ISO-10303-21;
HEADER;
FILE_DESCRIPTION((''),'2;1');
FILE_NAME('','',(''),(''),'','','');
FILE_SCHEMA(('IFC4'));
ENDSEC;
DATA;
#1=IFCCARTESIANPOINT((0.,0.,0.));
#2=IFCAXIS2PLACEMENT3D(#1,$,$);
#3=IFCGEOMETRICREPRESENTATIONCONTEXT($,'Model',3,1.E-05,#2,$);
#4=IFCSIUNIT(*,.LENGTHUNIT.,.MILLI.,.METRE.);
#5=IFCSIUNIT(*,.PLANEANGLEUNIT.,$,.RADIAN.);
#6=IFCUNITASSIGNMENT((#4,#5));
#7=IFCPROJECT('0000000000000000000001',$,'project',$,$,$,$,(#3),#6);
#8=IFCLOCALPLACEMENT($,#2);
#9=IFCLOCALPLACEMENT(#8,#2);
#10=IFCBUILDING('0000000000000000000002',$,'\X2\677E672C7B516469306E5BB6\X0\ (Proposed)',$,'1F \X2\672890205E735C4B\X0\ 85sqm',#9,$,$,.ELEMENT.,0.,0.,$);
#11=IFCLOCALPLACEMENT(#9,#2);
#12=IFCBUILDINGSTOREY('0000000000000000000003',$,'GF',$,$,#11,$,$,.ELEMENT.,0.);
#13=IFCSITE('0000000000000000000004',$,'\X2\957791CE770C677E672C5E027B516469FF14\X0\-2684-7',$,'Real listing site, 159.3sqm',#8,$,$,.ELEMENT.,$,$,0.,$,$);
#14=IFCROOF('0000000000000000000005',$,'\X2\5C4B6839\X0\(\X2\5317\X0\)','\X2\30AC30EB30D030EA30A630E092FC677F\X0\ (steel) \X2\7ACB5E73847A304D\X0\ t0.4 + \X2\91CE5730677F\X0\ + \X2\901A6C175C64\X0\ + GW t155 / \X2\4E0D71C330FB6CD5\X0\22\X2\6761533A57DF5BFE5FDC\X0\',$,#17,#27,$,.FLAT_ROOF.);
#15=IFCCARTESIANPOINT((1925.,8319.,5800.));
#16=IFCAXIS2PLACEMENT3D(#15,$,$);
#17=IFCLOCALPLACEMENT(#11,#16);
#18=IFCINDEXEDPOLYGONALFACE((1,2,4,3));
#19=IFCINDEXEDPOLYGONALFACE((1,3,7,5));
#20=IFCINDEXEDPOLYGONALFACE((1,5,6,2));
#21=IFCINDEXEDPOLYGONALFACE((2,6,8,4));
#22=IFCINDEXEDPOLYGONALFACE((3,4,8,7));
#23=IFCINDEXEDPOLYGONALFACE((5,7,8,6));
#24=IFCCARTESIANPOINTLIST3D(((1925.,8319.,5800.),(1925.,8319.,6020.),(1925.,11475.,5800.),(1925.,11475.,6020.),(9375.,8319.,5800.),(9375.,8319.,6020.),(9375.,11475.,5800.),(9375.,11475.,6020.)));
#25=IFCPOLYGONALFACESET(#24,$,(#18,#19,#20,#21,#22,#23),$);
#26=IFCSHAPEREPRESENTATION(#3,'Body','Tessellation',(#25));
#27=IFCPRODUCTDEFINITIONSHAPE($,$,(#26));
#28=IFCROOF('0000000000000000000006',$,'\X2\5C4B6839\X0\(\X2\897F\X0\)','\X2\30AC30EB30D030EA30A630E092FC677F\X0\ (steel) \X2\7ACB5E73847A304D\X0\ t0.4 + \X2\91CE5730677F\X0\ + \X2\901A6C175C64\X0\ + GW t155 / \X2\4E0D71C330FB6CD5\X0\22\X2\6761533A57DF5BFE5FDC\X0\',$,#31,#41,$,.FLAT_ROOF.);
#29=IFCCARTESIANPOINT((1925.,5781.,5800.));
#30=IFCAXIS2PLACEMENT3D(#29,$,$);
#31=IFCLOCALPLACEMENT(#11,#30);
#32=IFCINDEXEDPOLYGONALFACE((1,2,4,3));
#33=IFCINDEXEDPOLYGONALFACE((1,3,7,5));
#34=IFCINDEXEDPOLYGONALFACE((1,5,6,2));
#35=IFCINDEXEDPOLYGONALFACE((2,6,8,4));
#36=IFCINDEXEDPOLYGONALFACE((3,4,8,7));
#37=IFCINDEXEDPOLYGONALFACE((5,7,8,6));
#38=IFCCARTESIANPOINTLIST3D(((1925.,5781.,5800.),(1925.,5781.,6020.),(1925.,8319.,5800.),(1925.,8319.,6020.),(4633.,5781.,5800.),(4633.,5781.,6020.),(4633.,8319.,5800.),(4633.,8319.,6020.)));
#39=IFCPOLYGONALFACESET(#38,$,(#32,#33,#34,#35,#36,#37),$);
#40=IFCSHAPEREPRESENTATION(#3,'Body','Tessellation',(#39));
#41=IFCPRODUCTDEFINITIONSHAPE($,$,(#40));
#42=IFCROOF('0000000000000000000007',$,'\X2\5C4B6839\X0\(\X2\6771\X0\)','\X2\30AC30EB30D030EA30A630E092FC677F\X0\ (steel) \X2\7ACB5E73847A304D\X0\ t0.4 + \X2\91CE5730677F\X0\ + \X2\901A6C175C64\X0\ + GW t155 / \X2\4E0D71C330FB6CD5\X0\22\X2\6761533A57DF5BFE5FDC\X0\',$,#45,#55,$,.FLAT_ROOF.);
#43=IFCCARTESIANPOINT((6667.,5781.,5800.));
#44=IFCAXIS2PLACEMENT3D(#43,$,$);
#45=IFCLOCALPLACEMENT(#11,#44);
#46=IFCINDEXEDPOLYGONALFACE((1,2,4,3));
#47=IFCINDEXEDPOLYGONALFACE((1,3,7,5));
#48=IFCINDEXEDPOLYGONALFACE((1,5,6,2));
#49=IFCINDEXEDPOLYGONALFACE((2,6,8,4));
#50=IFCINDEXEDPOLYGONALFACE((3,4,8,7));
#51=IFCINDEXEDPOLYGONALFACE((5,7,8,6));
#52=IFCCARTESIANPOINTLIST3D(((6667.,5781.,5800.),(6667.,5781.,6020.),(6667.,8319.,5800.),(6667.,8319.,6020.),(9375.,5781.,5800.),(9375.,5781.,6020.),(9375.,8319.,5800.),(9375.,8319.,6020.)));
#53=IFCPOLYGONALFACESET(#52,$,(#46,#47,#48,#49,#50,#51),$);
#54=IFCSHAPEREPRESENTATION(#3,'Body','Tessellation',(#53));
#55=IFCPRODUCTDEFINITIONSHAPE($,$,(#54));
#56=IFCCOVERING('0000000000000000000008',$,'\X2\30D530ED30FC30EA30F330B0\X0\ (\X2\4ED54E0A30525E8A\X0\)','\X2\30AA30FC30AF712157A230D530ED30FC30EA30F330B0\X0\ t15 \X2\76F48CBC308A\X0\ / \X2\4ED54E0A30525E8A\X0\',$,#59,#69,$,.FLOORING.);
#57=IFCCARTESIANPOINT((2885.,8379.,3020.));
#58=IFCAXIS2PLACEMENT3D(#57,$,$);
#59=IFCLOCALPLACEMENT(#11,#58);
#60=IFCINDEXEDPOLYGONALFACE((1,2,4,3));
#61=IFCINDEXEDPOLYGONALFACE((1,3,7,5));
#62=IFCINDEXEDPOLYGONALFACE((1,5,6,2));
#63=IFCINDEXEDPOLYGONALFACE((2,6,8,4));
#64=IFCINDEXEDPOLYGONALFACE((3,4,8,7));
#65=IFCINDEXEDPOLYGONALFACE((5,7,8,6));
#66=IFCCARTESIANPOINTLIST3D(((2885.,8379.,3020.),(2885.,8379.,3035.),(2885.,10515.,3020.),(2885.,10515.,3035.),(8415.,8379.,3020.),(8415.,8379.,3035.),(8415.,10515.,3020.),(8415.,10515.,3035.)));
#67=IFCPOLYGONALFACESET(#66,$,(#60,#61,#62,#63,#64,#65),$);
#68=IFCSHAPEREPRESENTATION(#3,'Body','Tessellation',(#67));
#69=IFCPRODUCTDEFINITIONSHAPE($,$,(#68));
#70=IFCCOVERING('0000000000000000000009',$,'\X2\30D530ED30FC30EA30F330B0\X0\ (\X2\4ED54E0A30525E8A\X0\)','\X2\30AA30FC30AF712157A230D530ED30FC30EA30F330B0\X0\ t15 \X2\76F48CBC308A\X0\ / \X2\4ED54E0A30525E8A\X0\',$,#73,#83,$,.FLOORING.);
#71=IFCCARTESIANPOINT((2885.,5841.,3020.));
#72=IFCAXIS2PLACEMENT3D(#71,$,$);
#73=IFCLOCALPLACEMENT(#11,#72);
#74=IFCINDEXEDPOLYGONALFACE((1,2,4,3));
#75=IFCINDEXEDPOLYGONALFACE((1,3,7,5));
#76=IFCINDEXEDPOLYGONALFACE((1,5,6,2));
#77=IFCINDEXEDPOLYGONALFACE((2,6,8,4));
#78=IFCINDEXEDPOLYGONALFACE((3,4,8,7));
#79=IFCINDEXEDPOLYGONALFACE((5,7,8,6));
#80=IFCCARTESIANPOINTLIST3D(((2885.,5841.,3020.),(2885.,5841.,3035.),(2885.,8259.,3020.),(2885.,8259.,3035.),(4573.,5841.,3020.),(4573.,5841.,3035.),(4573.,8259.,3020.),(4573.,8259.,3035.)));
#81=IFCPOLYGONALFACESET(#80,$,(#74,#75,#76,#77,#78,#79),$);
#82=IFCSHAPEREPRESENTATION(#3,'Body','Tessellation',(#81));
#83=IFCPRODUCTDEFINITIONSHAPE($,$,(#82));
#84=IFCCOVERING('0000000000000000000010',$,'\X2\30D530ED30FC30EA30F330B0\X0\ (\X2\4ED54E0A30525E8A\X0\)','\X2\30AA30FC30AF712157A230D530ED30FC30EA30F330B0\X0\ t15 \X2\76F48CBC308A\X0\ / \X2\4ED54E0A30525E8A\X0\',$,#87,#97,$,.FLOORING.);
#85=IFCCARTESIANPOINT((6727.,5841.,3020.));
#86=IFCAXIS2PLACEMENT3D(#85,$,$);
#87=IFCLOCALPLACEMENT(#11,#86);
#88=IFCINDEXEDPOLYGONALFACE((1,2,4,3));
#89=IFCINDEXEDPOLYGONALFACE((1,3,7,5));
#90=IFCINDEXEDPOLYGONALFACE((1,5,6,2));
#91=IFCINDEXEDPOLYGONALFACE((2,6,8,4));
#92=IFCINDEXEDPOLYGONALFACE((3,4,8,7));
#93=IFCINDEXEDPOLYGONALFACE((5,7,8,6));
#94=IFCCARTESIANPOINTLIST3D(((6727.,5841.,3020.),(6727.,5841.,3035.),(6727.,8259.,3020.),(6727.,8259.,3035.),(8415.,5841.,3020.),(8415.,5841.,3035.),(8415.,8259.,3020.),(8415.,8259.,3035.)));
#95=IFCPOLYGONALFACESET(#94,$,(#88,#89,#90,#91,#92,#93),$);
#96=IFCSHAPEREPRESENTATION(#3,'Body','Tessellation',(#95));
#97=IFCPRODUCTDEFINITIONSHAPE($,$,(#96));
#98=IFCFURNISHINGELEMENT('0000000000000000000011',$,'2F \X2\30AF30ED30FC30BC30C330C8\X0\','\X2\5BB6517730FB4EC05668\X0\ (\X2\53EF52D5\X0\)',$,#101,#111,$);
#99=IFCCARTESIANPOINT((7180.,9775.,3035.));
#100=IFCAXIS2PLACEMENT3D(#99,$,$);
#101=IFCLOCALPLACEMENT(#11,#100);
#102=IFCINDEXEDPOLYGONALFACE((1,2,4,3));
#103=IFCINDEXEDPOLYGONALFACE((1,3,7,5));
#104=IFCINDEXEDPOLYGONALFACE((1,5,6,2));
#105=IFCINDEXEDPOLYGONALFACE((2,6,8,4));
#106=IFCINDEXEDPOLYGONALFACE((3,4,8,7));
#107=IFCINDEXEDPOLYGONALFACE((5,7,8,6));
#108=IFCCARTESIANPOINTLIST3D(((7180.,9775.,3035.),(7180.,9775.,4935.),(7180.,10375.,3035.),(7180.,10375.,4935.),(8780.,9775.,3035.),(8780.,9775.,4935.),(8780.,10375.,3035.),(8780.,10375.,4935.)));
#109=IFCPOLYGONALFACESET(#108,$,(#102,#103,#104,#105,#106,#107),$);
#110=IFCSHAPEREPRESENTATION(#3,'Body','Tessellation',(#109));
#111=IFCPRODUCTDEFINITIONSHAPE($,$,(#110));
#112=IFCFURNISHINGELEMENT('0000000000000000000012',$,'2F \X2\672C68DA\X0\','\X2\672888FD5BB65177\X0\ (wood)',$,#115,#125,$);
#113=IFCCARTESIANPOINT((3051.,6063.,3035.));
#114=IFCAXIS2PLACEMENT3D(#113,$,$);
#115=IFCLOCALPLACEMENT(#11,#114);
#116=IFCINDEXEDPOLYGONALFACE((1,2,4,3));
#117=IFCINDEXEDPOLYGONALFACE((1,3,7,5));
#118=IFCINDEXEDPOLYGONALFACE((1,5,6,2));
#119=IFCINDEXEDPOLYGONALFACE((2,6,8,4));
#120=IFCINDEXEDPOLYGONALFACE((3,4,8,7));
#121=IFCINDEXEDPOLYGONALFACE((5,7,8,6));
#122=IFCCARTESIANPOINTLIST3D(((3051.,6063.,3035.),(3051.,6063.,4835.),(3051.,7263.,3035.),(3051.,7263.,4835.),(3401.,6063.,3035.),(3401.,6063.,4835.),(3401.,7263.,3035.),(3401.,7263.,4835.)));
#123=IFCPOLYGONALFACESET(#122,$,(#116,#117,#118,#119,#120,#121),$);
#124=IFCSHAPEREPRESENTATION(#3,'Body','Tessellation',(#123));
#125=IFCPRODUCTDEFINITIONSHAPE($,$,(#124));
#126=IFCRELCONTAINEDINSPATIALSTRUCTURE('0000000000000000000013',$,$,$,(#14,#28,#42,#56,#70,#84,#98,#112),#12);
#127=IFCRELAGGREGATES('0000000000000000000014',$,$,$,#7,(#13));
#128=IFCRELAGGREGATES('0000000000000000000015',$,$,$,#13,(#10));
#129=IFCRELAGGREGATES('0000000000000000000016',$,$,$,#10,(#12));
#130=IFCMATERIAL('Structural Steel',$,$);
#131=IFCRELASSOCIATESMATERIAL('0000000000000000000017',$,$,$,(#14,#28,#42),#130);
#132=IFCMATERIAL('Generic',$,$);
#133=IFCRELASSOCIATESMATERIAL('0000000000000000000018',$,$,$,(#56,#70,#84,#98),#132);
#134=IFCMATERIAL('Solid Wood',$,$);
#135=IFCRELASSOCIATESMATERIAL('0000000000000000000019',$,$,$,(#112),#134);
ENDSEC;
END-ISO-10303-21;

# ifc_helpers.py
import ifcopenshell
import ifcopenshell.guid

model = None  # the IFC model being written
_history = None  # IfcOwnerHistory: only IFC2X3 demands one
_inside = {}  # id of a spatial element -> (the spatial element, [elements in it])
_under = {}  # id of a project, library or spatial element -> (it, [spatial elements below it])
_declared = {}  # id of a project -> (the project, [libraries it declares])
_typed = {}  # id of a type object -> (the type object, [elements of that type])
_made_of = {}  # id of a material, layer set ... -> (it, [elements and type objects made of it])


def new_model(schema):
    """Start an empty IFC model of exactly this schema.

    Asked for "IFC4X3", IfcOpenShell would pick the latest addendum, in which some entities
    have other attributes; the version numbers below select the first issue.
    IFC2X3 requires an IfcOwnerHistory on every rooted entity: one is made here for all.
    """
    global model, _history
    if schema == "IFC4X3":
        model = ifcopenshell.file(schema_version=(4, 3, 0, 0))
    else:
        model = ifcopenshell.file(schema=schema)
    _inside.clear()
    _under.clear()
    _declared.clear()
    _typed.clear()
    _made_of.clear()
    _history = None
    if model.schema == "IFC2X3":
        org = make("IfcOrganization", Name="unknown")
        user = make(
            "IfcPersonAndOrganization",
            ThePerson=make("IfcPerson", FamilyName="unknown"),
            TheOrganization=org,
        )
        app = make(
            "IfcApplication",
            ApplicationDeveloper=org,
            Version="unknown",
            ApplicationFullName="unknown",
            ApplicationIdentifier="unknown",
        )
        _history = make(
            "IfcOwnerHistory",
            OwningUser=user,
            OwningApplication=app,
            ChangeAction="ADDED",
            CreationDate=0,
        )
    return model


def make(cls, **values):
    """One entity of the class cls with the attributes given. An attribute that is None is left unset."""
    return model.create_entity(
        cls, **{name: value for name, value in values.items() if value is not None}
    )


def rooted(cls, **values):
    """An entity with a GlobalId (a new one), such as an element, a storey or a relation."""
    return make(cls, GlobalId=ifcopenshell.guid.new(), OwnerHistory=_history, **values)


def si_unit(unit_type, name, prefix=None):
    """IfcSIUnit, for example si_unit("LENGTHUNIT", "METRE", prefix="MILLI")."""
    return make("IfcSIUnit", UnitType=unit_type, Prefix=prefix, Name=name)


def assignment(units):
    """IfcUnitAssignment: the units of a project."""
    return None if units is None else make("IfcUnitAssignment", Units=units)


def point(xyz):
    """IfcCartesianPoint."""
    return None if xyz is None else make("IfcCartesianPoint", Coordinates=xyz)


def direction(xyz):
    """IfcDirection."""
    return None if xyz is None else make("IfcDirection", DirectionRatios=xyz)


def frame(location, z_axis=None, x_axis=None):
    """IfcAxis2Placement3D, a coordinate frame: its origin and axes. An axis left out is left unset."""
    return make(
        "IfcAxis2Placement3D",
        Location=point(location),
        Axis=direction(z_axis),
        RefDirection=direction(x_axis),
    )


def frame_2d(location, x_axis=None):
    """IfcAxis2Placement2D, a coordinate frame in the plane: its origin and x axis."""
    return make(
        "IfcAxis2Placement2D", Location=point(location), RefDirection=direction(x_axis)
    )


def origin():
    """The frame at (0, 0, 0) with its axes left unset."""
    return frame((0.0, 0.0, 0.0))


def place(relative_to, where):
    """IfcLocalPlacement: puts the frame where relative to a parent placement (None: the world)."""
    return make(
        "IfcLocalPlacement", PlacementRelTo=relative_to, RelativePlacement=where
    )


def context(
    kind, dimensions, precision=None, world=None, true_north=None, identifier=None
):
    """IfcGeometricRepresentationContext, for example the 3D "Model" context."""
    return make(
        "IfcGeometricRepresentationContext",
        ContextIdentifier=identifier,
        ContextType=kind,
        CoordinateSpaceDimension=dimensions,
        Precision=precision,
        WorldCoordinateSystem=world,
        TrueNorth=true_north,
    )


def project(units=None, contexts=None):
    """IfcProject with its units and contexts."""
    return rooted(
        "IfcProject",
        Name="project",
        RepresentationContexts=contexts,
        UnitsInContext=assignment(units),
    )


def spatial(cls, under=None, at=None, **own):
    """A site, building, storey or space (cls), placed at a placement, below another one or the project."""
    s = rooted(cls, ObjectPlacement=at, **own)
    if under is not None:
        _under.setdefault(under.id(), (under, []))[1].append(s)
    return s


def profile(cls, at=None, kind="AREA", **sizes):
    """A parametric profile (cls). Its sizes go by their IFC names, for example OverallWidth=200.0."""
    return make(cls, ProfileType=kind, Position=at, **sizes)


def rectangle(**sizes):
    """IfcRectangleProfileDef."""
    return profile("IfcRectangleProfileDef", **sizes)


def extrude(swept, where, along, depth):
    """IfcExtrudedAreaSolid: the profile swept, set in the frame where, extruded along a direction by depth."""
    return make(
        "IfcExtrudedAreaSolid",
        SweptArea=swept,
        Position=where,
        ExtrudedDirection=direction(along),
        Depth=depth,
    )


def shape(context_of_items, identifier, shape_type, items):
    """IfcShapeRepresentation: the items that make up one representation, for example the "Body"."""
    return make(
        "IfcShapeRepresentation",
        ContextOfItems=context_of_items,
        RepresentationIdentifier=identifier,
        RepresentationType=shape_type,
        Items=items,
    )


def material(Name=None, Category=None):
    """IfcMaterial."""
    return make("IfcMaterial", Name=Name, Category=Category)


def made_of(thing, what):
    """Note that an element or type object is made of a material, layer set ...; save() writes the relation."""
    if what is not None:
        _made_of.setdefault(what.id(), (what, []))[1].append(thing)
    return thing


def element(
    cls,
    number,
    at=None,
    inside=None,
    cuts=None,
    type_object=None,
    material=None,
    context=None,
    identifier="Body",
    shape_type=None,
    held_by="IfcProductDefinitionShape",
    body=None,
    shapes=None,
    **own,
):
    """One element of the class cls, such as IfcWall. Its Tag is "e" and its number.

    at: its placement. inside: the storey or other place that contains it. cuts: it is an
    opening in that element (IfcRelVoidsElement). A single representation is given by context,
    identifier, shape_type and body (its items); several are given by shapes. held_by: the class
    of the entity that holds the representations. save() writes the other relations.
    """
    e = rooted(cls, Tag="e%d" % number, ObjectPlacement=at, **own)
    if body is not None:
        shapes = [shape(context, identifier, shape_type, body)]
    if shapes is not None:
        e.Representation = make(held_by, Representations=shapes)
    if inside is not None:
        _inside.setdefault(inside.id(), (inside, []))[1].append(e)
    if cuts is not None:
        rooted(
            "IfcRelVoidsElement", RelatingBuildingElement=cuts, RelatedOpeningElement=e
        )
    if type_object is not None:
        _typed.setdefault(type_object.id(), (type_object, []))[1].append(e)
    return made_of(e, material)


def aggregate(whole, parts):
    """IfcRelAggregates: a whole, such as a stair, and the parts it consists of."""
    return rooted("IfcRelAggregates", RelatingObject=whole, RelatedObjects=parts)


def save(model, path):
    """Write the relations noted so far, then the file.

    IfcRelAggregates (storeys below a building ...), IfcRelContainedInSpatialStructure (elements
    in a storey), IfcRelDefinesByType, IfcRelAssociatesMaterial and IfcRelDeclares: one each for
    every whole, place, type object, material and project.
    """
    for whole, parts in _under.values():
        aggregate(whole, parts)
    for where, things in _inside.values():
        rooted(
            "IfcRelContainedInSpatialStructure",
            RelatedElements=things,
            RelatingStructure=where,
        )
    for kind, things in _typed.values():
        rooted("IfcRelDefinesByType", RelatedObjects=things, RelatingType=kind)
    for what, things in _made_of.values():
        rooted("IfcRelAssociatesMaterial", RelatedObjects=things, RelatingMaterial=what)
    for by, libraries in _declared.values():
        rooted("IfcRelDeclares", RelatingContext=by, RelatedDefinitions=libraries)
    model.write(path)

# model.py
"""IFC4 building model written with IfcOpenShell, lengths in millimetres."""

from ifc_helpers import new_model, si_unit, frame, frame_2d, origin, place, context, project, spatial, rectangle, extrude, material, element, save


model = new_model("IFC4")

# Units and contexts
model_context = context("Model", 3, precision=1e-05, world=origin())
ifc_project = project(units=[si_unit("LENGTHUNIT", "METRE", prefix="MILLI"), si_unit("PLANEANGLEUNIT", "RADIAN")], contexts=[model_context])

# Site, building, storey
site_placement = place(None, origin())
site = spatial("IfcSite", under=ifc_project, at=site_placement, Name="長野県松本市筑摩４-2684-7", ObjectType="Real listing site, 159.3sqm", CompositionType="ELEMENT", RefElevation=0.0)
building_placement = place(site_placement, origin())
building = spatial("IfcBuilding", under=site, at=building_placement, Name="松本筑摩の家 (Proposed)", ObjectType="1F 木造平屋 85sqm", CompositionType="ELEMENT", ElevationOfRefHeight=0.0, ElevationOfTerrain=0.0)
storey_placement = place(building_placement, origin())
storey = spatial("IfcBuildingStorey", under=building, at=storey_placement, Name="GF", CompositionType="ELEMENT", Elevation=0.0)

# Shared definitions
ifc_material_1 = material(Name="Solid Wood")

# Shared definitions
ifc_material_2 = material(Name="Generic")

# Roofs
ifc_material_3 = material(Name="Structural Steel")
for number, where, name in (
    (1, (1925.0, 8319.0, 5800.0), "屋根(北)"),
):
    element("IfcRoof", number, at=place(storey_placement, frame(where)), inside=storey, material=ifc_material_3, Name=name, Description="ガルバリウム鋼板 (steel) 立平葺き t0.4 + 野地板 + 通気層 + GW t155 / 不燃・法22条区域対応", PredefinedType="FLAT_ROOF", context=model_context, shape_type="SweptSolid", body=[
        extrude(rectangle(XDim=7450.0, YDim=3156.0, at=frame_2d((3725.0, 1578.0))), frame((1925.0, 8319.0, 5800.0)), (0.0, 0.0, 1.0), 220.0),
    ])
roof_1_placement = place(storey_placement, frame((1925.0, 5781.0, 5800.0)))
element("IfcRoof", 2, at=roof_1_placement, inside=storey, material=ifc_material_3, Name="屋根(西)", Description="ガルバリウム鋼板 (steel) 立平葺き t0.4 + 野地板 + 通気層 + GW t155 / 不燃・法22条区域対応", PredefinedType="FLAT_ROOF", context=model_context, shape_type="SweptSolid", body=[
    extrude(rectangle(XDim=2708.0, YDim=2538.0, at=frame_2d((1354.0, 1269.0))), frame((1925.0, 5781.0, 5800.0)), (0.0, 0.0, 1.0), 220.0),
])
roof_2_placement = place(storey_placement, frame((6667.0, 5781.0, 5800.0)))
element("IfcRoof", 3, at=roof_2_placement, inside=storey, material=ifc_material_3, Name="屋根(東)", Description="ガルバリウム鋼板 (steel) 立平葺き t0.4 + 野地板 + 通気層 + GW t155 / 不燃・法22条区域対応", PredefinedType="FLAT_ROOF", context=model_context, shape_type="SweptSolid", body=[
    extrude(rectangle(XDim=2708.0, YDim=2538.0, at=frame_2d((1354.0, 1269.0))), frame((6667.0, 5781.0, 5800.0)), (0.0, 0.0, 1.0), 220.0),
])

# Coverings
covering_1_placement = place(storey_placement, frame((2885.0, 8379.0, 3020.0)))
element("IfcCovering", 4, at=covering_1_placement, inside=storey, material=ifc_material_2, Name="フローリング (仕上げ床)", Description="オーク無垢フローリング t15 直貼り / 仕上げ床", PredefinedType="FLOORING", context=model_context, shape_type="SweptSolid", body=[
    extrude(rectangle(XDim=5530.0, YDim=2136.0, at=frame_2d((2765.0, 1068.0))), frame((2885.0, 8379.0, 3020.0)), (0.0, 0.0, 1.0), 15.0),
])
covering_2_placement = place(storey_placement, frame((2885.0, 5841.0, 3020.0)))
element("IfcCovering", 5, at=covering_2_placement, inside=storey, material=ifc_material_2, Name="フローリング (仕上げ床)", Description="オーク無垢フローリング t15 直貼り / 仕上げ床", PredefinedType="FLOORING", context=model_context, shape_type="SweptSolid", body=[
    extrude(rectangle(XDim=1688.0, YDim=2418.0, at=frame_2d((844.0, 1209.0))), frame((2885.0, 5841.0, 3020.0)), (0.0, 0.0, 1.0), 15.0),
])
covering_3_placement = place(storey_placement, frame((6727.0, 5841.0, 3020.0)))
element("IfcCovering", 6, at=covering_3_placement, inside=storey, material=ifc_material_2, Name="フローリング (仕上げ床)", Description="オーク無垢フローリング t15 直貼り / 仕上げ床", PredefinedType="FLOORING", context=model_context, shape_type="SweptSolid", body=[
    extrude(rectangle(XDim=1688.0, YDim=2418.0, at=frame_2d((844.0, 1209.0))), frame((6727.0, 5841.0, 3020.0)), (0.0, 0.0, 1.0), 15.0),
])

# Furnishing elements
furnishing_1_placement = place(storey_placement, frame((7180.0, 9775.0, 3035.0)))
element("IfcFurnishingElement", 7, at=furnishing_1_placement, inside=storey, material=ifc_material_2, Name="2F クローゼット", Description="家具・什器 (可動)", context=model_context, shape_type="SweptSolid", body=[
    extrude(rectangle(XDim=1600.0, YDim=600.0, at=frame_2d((800.0, 300.0))), frame((7180.0, 9775.0, 3035.0)), (0.0, 0.0, 1.0), 1900.0),
])
furnishing_2_placement = place(storey_placement, frame((3051.0, 6063.0, 3035.0)))
element("IfcFurnishingElement", 8, at=furnishing_2_placement, inside=storey, material=ifc_material_1, Name="2F 本棚", Description="木製家具 (wood)", context=model_context, shape_type="SweptSolid", body=[
    extrude(rectangle(XDim=350.0, YDim=1200.0, at=frame_2d((175.0, 600.0))), frame((3051.0, 6063.0, 3035.0)), (0.0, 0.0, 1.0), 1800.0),
])

save(model, "model.ifc")
